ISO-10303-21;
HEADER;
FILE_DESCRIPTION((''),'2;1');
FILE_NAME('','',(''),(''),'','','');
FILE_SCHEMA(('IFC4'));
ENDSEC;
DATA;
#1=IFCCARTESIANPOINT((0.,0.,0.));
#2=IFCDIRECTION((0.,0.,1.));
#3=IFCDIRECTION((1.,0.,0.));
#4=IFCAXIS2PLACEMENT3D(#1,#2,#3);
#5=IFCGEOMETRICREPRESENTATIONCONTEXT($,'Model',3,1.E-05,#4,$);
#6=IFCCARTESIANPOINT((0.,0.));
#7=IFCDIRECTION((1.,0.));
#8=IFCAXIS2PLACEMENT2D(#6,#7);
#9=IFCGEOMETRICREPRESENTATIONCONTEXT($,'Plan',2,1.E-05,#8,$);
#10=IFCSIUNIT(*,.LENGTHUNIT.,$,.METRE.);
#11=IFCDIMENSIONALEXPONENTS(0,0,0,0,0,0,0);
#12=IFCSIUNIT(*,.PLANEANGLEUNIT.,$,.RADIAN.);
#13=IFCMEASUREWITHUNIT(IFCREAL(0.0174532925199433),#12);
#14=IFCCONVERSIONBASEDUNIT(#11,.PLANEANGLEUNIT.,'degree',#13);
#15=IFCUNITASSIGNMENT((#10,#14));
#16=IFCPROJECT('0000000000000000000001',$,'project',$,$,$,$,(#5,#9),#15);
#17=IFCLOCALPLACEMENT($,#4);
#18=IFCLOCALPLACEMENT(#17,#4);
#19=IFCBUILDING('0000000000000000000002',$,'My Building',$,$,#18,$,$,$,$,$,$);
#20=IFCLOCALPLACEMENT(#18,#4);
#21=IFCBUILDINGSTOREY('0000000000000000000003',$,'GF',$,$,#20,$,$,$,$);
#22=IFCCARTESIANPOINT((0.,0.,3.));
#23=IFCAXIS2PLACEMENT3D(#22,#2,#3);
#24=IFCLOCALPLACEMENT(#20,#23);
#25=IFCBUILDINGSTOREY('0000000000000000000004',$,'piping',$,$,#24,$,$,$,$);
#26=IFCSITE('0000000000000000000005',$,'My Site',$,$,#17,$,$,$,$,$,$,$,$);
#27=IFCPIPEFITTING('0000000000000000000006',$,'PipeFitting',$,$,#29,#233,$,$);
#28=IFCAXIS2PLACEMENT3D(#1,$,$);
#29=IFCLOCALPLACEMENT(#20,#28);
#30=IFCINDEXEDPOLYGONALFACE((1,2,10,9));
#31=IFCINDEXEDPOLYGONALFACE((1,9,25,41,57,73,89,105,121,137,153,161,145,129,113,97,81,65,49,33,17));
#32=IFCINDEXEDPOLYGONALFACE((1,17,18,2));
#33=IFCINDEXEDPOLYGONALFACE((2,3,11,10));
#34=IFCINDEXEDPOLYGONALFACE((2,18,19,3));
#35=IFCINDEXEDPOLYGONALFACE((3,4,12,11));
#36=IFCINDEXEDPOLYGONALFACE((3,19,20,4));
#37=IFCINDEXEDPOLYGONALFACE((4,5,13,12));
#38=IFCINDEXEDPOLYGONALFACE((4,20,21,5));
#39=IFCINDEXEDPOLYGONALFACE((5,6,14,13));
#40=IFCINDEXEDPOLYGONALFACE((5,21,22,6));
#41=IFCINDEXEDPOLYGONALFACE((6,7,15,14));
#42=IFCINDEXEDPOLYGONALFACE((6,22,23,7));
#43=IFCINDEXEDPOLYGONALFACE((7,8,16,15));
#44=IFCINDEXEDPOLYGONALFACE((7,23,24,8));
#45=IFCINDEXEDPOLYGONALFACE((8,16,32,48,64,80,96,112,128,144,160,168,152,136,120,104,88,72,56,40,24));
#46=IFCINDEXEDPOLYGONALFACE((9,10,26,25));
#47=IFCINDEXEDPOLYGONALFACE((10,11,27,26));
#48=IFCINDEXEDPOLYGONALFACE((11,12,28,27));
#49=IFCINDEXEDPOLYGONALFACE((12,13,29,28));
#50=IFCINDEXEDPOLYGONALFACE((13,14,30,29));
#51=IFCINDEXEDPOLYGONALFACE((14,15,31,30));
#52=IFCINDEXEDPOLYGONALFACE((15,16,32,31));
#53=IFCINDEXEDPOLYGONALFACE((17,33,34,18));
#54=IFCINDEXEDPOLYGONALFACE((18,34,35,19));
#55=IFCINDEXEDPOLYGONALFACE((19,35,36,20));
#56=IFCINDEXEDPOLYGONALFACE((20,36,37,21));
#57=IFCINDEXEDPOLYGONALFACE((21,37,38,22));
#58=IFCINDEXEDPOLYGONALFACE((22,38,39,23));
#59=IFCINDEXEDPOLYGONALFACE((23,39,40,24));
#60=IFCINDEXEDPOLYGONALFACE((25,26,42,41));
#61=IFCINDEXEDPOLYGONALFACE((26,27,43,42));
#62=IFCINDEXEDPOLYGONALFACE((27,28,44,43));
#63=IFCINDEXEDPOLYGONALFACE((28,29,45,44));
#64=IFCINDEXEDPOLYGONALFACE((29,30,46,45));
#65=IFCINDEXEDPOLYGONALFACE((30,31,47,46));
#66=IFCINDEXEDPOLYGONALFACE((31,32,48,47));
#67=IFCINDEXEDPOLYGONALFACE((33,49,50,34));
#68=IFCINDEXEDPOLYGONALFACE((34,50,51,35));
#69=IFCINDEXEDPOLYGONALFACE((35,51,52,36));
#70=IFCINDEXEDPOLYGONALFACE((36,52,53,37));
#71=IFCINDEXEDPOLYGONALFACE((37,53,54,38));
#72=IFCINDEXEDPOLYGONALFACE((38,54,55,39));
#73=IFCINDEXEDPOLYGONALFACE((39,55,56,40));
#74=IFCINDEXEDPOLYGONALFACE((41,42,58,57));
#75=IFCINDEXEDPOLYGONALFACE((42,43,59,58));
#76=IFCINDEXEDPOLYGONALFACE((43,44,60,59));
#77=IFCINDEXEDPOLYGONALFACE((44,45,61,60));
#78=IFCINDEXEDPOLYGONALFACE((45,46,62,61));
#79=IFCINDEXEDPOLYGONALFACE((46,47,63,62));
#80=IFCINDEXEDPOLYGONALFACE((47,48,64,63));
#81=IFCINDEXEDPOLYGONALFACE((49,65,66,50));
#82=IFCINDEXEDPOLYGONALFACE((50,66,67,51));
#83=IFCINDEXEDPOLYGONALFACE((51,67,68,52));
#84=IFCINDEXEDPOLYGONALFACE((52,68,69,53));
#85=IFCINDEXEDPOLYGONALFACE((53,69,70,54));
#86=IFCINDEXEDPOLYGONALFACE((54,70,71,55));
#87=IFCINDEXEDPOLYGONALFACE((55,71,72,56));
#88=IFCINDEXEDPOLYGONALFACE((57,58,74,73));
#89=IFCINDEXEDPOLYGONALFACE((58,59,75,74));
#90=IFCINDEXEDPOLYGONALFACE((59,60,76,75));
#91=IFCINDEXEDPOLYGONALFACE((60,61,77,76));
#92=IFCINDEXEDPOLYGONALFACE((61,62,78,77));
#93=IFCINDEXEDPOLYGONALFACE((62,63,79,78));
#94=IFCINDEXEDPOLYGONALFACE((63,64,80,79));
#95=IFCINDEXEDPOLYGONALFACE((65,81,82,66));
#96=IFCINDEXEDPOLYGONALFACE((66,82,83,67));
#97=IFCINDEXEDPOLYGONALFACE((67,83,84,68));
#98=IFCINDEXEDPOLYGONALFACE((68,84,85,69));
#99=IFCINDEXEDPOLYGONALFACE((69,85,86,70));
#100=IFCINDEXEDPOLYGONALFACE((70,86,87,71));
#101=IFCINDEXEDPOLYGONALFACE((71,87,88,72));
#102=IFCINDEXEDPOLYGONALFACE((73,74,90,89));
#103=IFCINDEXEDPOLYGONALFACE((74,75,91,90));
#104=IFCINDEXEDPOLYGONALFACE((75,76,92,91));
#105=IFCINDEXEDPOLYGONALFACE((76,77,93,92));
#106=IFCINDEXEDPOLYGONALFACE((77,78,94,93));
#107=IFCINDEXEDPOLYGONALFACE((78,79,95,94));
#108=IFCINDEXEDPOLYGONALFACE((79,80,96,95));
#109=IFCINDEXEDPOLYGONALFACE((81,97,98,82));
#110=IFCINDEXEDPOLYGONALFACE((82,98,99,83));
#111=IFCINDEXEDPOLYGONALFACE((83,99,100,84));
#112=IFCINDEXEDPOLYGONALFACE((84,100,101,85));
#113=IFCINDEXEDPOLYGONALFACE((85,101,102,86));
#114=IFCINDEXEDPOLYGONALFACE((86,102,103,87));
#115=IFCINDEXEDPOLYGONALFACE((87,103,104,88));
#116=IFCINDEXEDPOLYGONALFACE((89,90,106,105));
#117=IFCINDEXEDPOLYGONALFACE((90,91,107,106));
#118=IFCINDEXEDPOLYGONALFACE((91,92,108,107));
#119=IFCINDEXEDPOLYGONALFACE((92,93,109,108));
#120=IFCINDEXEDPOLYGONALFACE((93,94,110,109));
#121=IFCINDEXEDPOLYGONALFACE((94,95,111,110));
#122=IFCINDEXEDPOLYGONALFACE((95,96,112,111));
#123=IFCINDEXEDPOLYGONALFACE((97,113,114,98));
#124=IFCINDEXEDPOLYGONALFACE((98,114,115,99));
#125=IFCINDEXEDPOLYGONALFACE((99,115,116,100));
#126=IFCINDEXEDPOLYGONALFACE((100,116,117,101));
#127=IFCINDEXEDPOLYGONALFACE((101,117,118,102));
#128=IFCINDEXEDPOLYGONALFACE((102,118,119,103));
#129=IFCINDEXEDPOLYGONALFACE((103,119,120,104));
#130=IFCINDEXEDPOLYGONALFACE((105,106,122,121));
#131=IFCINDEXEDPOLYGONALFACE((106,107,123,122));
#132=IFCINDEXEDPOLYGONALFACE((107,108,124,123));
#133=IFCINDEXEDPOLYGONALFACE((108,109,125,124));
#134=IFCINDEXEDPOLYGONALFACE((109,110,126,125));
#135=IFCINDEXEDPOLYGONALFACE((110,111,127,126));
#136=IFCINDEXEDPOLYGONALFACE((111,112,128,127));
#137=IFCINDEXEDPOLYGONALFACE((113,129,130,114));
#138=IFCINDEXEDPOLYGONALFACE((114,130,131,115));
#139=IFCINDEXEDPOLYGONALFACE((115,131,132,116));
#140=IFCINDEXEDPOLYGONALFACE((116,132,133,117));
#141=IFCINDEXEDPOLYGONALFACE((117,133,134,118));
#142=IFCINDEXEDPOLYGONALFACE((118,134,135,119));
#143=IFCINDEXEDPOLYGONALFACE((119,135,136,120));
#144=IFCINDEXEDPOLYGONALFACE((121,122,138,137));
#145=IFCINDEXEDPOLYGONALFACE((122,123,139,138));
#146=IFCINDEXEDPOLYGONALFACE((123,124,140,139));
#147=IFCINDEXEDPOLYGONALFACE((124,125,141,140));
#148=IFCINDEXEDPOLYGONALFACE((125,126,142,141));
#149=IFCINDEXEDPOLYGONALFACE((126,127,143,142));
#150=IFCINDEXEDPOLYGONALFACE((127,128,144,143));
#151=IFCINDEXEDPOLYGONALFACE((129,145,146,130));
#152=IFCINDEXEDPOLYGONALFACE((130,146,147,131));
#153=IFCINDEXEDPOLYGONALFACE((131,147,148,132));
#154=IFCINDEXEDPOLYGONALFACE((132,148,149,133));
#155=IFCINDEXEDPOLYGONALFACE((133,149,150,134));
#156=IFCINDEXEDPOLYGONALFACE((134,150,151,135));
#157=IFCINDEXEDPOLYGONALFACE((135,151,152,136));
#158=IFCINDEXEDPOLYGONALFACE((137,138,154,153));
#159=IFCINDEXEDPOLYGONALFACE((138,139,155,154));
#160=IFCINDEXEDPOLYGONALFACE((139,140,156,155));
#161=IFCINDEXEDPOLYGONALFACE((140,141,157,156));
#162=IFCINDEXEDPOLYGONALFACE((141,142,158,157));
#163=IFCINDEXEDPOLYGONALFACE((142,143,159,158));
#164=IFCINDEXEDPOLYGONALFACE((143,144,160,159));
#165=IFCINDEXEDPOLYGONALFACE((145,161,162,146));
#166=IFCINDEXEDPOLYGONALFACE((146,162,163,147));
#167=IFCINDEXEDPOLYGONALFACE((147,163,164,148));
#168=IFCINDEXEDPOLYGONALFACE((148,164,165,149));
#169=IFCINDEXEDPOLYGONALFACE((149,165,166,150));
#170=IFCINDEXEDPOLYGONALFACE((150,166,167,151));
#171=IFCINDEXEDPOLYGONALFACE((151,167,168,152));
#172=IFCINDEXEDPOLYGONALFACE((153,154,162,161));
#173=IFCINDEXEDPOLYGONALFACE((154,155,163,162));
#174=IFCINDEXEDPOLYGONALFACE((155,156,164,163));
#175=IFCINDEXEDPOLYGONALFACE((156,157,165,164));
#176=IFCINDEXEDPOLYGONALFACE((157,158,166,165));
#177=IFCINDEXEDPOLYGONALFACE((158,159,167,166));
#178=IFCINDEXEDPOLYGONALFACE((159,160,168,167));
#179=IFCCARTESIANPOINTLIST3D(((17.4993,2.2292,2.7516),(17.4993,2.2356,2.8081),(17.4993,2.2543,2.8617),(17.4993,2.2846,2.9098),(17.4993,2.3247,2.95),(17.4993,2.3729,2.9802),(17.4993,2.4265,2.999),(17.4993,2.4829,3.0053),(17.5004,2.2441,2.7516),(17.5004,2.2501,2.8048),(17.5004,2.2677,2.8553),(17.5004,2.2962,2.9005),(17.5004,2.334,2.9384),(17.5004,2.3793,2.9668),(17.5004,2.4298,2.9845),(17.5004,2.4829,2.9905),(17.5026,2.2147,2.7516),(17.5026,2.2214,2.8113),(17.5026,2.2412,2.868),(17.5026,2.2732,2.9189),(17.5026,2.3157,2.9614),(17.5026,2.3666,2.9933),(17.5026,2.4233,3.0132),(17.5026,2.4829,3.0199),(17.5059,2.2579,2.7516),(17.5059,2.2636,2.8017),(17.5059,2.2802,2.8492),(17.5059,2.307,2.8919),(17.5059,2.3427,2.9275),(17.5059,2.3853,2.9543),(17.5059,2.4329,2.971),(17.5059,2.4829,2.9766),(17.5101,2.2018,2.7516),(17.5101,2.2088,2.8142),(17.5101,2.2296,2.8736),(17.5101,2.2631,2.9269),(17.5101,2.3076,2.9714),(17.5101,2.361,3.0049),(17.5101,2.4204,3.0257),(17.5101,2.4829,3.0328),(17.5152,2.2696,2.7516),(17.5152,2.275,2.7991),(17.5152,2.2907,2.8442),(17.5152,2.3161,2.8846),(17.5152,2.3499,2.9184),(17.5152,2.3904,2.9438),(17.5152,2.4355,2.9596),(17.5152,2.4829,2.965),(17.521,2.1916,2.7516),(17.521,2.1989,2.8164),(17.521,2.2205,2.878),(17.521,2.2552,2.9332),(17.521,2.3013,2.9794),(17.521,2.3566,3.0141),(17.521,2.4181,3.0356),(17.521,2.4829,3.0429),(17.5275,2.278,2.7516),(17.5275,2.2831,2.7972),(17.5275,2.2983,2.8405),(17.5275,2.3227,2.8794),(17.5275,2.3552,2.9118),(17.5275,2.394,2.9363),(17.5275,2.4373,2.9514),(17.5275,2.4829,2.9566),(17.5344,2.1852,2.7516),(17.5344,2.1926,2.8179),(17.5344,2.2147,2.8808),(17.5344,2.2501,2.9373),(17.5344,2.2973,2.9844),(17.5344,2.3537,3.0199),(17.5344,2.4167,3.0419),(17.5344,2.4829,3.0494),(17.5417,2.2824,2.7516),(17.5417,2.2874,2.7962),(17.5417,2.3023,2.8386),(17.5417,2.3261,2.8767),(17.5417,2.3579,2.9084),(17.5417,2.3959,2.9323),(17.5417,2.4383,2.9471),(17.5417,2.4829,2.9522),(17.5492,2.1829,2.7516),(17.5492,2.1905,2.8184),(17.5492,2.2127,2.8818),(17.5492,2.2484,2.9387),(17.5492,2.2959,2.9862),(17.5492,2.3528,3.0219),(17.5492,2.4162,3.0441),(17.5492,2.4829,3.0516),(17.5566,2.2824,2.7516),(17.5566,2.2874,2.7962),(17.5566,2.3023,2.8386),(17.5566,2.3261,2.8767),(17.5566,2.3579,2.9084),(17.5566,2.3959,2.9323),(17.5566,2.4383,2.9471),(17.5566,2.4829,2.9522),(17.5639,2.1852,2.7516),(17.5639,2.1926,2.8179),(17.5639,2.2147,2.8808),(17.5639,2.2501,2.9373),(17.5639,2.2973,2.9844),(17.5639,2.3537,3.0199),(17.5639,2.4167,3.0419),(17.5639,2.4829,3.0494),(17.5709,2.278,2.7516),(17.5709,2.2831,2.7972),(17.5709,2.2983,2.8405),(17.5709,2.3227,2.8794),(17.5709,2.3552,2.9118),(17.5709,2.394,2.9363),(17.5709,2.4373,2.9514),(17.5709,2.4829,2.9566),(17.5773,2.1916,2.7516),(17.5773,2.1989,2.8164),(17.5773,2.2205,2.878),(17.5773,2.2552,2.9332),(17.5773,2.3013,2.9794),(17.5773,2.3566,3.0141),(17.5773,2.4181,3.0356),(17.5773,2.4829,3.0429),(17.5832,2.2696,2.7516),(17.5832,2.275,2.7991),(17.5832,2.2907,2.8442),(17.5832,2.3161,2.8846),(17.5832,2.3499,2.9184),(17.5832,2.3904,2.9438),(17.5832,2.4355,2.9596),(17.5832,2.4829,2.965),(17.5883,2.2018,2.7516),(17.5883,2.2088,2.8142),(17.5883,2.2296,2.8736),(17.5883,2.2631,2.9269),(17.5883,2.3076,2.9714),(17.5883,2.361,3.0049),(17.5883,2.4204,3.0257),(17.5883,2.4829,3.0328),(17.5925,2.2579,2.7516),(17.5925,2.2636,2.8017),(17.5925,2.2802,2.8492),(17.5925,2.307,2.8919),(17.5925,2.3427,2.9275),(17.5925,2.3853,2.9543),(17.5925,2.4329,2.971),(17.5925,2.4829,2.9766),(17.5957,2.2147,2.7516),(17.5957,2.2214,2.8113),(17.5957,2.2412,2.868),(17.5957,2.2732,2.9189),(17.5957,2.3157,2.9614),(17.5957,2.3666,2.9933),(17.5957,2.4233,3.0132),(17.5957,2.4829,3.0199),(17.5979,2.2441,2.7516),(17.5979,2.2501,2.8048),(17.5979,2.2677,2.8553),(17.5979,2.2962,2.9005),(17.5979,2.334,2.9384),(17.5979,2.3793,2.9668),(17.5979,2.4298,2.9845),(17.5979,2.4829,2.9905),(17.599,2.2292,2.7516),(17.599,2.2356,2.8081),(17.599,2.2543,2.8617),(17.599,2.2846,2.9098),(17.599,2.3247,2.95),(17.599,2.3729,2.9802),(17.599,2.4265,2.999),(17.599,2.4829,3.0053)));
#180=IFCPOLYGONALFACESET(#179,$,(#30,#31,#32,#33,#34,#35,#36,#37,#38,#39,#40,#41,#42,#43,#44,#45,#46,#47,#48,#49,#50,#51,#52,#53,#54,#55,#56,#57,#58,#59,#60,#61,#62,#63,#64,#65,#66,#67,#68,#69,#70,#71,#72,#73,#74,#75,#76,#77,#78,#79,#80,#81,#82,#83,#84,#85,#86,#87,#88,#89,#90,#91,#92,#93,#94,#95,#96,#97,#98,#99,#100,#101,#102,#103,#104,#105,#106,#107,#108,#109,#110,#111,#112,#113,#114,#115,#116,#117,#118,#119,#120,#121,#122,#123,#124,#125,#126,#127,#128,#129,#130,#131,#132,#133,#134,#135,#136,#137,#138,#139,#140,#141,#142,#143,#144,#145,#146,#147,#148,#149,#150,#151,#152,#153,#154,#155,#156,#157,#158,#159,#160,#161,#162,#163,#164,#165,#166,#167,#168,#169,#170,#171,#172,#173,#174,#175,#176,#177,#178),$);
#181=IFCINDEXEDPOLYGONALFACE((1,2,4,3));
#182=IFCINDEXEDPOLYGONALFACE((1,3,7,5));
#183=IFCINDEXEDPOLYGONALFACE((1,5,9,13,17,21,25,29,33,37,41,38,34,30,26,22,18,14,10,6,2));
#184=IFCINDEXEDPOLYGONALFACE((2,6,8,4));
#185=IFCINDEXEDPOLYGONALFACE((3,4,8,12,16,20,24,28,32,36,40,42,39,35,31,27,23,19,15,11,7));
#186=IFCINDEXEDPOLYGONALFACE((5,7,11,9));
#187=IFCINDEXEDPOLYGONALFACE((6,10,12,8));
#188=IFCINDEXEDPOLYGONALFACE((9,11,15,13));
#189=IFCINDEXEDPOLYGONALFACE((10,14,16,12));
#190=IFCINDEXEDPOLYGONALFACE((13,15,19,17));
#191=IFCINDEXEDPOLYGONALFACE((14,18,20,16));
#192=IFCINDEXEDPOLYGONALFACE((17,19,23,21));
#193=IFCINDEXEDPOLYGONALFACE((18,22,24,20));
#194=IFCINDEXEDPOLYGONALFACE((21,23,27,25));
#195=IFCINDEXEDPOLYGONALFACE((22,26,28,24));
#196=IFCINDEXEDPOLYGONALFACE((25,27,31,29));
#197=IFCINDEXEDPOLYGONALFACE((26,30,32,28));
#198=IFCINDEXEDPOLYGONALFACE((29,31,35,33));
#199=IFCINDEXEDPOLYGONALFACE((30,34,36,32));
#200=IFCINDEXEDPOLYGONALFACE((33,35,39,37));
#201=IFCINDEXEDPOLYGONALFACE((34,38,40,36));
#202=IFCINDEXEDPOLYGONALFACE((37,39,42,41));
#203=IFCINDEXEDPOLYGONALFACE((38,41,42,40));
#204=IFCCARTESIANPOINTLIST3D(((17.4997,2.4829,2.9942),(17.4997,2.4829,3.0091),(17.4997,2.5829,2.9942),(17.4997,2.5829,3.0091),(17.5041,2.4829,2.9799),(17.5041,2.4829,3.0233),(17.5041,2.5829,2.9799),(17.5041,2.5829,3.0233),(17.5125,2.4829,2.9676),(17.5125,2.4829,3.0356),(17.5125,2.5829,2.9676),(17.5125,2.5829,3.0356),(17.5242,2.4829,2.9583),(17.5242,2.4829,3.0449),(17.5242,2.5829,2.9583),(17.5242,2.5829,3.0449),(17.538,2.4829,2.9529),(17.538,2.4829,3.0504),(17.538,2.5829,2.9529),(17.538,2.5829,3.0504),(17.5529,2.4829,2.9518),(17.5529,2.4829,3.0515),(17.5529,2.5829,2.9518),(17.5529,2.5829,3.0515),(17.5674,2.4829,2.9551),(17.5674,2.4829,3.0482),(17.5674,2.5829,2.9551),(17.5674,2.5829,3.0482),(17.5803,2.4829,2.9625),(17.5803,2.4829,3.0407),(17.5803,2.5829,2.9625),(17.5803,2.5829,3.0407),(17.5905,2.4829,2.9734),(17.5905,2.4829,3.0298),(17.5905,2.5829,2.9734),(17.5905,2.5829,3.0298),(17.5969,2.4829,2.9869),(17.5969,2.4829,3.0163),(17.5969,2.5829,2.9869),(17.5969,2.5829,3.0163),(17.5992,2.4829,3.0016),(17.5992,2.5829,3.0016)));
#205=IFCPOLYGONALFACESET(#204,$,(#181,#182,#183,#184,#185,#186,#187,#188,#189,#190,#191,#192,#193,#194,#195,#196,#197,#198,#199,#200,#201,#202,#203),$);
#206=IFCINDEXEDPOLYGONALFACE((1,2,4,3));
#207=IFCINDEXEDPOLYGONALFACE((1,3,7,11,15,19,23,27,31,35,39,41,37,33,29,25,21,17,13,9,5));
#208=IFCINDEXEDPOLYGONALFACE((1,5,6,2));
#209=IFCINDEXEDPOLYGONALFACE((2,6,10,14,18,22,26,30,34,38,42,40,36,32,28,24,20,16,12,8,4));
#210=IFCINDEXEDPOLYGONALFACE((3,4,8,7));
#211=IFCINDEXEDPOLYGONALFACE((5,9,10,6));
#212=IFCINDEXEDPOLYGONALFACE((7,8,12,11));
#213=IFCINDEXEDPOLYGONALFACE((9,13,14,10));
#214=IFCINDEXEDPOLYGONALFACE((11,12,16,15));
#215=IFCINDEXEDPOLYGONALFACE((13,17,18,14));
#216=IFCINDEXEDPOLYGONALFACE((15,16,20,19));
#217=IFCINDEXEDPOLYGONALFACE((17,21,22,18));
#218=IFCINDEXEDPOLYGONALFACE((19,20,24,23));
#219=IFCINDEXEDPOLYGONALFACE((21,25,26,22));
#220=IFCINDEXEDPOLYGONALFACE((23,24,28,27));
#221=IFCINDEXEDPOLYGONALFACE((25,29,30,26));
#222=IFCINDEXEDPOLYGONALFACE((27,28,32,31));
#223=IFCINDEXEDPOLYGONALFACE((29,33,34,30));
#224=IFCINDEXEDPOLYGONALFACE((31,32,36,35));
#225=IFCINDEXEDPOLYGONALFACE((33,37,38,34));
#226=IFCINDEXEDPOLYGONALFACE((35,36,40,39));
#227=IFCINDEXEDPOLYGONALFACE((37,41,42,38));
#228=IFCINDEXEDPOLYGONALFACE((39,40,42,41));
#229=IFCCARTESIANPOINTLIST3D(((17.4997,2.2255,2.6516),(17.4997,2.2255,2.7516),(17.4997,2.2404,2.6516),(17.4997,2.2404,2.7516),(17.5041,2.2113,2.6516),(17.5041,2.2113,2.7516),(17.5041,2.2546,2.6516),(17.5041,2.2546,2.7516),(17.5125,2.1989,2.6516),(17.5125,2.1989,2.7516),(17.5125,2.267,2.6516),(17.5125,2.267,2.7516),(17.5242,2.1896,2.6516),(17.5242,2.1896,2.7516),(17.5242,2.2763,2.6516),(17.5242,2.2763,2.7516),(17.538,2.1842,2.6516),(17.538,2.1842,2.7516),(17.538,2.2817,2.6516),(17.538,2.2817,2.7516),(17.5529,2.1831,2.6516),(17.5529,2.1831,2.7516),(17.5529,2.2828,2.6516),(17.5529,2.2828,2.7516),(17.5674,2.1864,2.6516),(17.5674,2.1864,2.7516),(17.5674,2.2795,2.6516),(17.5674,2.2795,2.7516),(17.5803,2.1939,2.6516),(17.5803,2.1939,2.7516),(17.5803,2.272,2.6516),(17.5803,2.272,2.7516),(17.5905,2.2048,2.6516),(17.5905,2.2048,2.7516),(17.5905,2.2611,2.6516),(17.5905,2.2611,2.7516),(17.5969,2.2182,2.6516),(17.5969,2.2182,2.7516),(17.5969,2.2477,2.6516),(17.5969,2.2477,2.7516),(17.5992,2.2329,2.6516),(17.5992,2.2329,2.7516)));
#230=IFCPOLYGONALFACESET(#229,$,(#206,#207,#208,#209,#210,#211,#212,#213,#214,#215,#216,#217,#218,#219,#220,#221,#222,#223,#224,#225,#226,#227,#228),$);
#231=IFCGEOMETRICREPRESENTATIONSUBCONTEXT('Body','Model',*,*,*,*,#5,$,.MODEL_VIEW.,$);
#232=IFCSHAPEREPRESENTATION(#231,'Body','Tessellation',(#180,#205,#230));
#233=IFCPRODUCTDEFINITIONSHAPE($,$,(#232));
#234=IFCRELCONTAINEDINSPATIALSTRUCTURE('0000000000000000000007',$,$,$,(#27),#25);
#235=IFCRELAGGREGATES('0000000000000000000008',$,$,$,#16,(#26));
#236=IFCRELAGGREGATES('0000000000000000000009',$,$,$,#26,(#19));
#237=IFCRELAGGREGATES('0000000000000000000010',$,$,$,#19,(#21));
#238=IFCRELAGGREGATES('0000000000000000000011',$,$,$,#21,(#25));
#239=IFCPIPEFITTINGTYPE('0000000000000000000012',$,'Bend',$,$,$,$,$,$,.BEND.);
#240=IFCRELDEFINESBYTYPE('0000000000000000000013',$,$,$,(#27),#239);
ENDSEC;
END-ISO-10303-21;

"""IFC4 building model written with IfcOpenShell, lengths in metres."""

from ifc_helpers import new_model, entity, si_unit, converted_unit, frame, origin_with_axes, origin_2d_with_axis, place, context, subcontext, project, spatial, circle, extrude, source, transform, mapped, type_object, type_shapes, element, save


model = new_model("IFC4")

# Units and contexts
model_context = context("Model", 3, precision=1e-05, world=origin_with_axes())
plan_context = context("Plan", 2, precision=1e-05, world=origin_2d_with_axis())
body_context = subcontext(model_context, "Body", "Model", "MODEL_VIEW")
ifc_project = project(units=[si_unit("LENGTHUNIT", "METRE"), converted_unit("PLANEANGLEUNIT", "degree", entity("IfcReal", 0.0174532925199433), si_unit("PLANEANGLEUNIT", "RADIAN"), dimensions=[0, 0, 0, 0, 0, 0, 0])], contexts=[model_context, plan_context])

# Site, building, storeys
site_placement = place(None, origin_with_axes())
site = spatial("IfcSite", under=ifc_project, at=site_placement, Name="My Site")
building_placement = place(site_placement, origin_with_axes())
building = spatial("IfcBuilding", under=site, at=building_placement, Name="My Building")
storey_1_placement = place(building_placement, origin_with_axes())
storey_1 = spatial("IfcBuildingStorey", under=building, at=storey_1_placement, Name="GF")
storey_2_placement = place(storey_1_placement, frame((0.0, 0.0, 3.0), z_axis=(0.0, 0.0, 1.0), x_axis=(1.0, 0.0, 0.0)))
storey_2 = spatial("IfcBuildingStorey", under=storey_1, at=storey_2_placement, Name="piping")

# Pipe fitting
pipe_fitting_type = type_object("IfcPipeFittingType", Name="Bend", PredefinedType="BEND")
shared_shape = source(origin_with_axes(), body_context, "Body", "SolidModel", [
    entity("IfcSweptDiskSolid", entity("IfcIndexedPolyCurve", entity("IfcCartesianPointList3D", [[0.0, 0.0, -0.1], [0.0, 0.0732, -0.2768], [0.0, 0.25, -0.35]]), [entity("IfcArcIndex", [1, 2, 3])]), 0.05),
    extrude(circle(Radius=0.05), origin_with_axes(), (0.0, 0.0, -1.0), 0.1),
    extrude(circle(Radius=0.05), frame((0.0, 0.25, -0.35), z_axis=(0.0, 1.0, 0.0), x_axis=(1.0, 0.0, 0.0)), (0.0, 0.0, 1.0), 0.1),
])
type_shapes(pipe_fitting_type, [shared_shape])
for number, where, z_axis, x_axis, name in (
    (1, (17.5492, 2.5829, 0.0016), (0.0, 1.0, 0.0), (1.0, 0.0, 0.0), "PipeFitting"),
):
    element("IfcPipeFitting", number, at=place(storey_2_placement, frame(where, z_axis=z_axis, x_axis=x_axis)), inside=storey_2, type_object=pipe_fitting_type, Name=name, context=body_context, shape_type="MappedRepresentation", body=[
        mapped(shared_shape, transform((0.0, 0.0, 0.0), x_axis=(1.0, 0.0, 0.0), y_axis=(0.0, 1.0, 0.0), z_axis=(0.0, 0.0, 1.0), scale=1.0)),
    ])

save(model, "model.ifc")
